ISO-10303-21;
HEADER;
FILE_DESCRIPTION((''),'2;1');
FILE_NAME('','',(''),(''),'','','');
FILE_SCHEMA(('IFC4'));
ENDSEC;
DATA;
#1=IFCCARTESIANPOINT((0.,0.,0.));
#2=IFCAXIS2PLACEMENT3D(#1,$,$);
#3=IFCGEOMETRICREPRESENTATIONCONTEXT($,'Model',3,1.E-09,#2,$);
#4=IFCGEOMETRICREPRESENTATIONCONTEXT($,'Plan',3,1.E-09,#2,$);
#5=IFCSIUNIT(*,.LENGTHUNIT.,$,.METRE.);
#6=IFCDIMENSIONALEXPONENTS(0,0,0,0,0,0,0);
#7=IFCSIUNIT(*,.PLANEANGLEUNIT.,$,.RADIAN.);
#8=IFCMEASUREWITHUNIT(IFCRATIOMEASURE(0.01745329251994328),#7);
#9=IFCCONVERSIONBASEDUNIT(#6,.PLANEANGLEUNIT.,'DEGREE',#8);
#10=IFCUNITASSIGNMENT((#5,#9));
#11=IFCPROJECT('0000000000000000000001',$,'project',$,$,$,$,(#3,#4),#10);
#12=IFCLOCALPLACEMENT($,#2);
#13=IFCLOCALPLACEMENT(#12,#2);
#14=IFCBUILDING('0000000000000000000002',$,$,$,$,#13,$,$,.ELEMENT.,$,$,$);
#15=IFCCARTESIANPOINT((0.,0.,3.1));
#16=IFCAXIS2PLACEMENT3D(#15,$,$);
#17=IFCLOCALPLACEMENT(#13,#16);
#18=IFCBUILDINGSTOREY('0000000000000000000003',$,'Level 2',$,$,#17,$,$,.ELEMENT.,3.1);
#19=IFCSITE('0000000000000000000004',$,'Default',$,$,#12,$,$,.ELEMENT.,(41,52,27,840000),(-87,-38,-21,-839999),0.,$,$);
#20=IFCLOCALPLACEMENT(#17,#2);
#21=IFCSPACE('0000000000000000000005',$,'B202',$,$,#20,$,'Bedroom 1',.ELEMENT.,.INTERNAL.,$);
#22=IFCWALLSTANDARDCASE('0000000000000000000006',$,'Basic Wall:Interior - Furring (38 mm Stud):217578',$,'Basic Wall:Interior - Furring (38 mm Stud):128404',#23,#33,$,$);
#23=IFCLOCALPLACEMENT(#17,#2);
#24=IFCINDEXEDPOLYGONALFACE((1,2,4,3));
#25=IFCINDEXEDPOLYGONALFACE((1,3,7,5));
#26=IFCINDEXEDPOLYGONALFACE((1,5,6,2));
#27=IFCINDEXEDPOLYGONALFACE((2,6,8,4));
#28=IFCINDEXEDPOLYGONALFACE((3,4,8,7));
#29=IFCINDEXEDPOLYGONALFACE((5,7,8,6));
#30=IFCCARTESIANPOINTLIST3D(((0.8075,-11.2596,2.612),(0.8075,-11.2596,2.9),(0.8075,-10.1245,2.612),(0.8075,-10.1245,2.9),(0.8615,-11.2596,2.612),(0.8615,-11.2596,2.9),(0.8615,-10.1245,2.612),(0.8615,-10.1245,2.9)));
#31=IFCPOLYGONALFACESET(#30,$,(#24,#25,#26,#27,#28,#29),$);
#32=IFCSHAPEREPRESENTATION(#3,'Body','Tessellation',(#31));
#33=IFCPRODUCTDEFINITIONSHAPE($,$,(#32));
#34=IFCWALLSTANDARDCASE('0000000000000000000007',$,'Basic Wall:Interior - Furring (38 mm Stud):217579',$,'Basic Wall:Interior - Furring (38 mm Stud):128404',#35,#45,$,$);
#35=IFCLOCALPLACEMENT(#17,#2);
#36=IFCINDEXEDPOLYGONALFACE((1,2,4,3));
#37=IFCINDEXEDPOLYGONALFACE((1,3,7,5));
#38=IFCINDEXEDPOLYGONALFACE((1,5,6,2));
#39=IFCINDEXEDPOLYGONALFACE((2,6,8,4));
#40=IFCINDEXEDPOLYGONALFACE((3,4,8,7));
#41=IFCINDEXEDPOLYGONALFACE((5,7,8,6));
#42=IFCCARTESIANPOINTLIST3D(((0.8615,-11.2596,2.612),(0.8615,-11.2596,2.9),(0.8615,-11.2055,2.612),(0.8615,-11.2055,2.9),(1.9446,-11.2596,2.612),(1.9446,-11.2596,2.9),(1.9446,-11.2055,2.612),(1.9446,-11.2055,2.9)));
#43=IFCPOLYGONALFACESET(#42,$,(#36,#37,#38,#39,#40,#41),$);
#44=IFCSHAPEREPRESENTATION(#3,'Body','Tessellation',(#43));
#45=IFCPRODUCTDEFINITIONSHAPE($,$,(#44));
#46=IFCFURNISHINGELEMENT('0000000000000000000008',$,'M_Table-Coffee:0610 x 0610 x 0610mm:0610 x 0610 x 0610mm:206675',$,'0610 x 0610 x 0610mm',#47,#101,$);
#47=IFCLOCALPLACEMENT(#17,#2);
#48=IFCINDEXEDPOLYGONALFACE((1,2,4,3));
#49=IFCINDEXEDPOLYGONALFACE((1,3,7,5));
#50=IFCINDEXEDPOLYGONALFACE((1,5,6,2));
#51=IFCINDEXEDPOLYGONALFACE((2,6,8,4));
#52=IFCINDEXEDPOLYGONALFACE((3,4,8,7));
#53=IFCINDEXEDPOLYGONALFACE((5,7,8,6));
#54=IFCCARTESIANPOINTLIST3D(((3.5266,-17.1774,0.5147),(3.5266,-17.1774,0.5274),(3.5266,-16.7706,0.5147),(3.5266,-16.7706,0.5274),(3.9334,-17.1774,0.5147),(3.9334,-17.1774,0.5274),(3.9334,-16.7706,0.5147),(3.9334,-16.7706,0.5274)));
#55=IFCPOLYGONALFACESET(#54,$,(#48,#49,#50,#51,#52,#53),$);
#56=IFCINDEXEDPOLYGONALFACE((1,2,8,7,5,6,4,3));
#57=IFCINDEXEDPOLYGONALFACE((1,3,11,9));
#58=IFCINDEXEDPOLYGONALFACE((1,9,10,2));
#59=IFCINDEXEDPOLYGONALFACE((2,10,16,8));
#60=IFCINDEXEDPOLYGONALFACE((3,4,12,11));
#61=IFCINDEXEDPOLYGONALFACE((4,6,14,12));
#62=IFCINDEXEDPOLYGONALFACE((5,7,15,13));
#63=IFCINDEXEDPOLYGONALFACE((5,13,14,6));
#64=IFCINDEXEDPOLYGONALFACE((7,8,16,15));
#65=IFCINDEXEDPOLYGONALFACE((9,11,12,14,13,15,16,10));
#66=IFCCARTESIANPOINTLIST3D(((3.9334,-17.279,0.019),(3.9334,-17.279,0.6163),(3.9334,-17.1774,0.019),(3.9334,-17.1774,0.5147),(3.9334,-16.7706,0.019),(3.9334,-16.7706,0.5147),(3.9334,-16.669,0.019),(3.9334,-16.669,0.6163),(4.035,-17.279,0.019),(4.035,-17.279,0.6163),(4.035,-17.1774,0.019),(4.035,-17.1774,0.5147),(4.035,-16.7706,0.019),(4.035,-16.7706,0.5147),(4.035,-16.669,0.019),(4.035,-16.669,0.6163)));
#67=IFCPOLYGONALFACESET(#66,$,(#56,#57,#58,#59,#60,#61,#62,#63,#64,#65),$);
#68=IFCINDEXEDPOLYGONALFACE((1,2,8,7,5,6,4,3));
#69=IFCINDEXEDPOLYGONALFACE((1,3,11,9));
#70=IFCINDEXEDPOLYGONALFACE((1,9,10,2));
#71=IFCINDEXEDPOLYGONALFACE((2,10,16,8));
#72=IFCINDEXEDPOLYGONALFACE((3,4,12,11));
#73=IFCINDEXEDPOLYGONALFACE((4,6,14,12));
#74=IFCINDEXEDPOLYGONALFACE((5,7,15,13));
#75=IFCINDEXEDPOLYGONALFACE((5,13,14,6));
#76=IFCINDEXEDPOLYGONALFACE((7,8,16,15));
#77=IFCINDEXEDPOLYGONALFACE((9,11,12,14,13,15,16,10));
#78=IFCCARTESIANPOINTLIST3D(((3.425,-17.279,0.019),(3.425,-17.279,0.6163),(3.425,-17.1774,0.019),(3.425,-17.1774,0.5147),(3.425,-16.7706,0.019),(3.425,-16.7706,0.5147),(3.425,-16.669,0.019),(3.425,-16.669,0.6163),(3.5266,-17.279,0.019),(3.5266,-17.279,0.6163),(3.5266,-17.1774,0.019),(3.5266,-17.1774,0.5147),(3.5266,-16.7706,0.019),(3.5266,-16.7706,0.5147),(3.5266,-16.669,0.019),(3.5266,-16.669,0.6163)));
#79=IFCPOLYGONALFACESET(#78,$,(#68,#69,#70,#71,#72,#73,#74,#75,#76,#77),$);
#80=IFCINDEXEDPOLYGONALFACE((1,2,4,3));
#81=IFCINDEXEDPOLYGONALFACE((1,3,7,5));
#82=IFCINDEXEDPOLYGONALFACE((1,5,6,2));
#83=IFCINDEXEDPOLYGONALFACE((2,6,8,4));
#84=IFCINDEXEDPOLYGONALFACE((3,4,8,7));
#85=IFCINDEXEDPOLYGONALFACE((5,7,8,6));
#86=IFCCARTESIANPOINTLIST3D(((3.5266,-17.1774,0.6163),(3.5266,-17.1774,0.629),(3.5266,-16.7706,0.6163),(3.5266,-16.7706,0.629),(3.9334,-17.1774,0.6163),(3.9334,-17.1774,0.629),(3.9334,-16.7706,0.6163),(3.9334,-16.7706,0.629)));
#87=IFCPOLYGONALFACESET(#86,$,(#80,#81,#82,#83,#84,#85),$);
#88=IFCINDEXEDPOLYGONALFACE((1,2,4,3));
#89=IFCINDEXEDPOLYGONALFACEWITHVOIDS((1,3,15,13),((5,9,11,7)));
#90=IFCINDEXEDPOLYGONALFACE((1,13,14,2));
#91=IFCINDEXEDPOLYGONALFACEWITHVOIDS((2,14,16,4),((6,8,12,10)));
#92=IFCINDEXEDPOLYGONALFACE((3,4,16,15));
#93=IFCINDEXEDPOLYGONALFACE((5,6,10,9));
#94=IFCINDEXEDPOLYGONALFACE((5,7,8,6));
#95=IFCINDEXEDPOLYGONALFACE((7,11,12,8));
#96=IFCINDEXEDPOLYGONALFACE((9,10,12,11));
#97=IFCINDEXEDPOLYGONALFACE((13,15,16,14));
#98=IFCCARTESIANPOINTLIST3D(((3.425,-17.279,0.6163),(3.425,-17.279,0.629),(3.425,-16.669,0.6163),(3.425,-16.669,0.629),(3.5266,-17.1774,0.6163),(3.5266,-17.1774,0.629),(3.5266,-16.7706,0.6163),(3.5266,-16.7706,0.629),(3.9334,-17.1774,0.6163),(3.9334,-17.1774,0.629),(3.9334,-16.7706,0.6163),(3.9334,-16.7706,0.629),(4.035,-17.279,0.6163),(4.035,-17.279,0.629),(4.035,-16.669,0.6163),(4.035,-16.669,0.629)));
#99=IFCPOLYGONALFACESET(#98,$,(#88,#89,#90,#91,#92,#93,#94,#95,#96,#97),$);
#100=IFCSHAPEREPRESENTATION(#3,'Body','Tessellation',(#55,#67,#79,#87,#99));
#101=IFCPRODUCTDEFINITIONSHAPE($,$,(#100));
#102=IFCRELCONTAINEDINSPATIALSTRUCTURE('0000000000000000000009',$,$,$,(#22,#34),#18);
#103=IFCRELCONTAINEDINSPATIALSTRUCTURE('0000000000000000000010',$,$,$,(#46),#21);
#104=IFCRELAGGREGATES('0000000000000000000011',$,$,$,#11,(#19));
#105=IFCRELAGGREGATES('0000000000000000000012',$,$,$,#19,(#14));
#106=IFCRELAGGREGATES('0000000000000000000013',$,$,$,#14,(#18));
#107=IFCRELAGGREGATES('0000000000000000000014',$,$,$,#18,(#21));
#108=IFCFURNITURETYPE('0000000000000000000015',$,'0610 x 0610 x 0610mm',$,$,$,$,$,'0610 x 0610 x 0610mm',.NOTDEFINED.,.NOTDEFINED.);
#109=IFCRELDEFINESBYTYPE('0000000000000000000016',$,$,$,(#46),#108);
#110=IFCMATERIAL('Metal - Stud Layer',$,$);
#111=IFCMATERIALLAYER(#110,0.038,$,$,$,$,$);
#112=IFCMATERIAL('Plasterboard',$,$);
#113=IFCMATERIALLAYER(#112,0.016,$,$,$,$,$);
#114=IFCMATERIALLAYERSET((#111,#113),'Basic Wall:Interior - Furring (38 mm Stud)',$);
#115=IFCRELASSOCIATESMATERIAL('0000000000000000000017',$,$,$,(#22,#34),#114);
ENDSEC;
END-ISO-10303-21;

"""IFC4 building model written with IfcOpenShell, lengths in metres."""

from ifc_helpers import new_model, entity, si_unit, converted_unit, frame, frame_2d, origin, origin_2d_with_axis, place, context, project, spatial, polyline, rectangle, outline, extrude, source, transform, mapped, material, layer, layer_set, layer_usage, type_object, type_shapes, element, save


model = new_model("IFC4")

# Units and contexts
model_context = context("Model", 3, precision=1e-09, world=origin())
plan_context = context("Plan", 3, precision=1e-09, world=origin())
ifc_project = project(units=[si_unit("LENGTHUNIT", "METRE"), converted_unit("PLANEANGLEUNIT", "DEGREE", entity("IfcRatioMeasure", 0.01745329251994328), si_unit("PLANEANGLEUNIT", "RADIAN"), dimensions=[0, 0, 0, 0, 0, 0, 0])], contexts=[model_context, plan_context])

# Site, building, storey
site_placement = place(None, origin())
site = spatial("IfcSite", under=ifc_project, at=site_placement, Name="Default", CompositionType="ELEMENT", RefLatitude=(41, 52, 27, 840000), RefLongitude=(-87, -38, -21, -839999), RefElevation=0.0)
building_placement = place(site_placement, origin())
building = spatial("IfcBuilding", under=site, at=building_placement, CompositionType="ELEMENT")
storey_placement = place(building_placement, frame((0.0, 0.0, 3.1)))
storey = spatial("IfcBuildingStorey", under=building, at=storey_placement, Name="Level 2", CompositionType="ELEMENT", Elevation=3.1)

# Shared definitions
ifc_material_1 = material(Name="Metal - Stud Layer")
ifc_material_2 = material(Name="Plasterboard")

# Walls
ifc_layer_1 = layer(ifc_material_1, 0.038)
ifc_layer_2 = layer(ifc_material_2, 0.016)
ifc_layer_set_1 = layer_set([ifc_layer_1, ifc_layer_2], Name="Basic Wall:Interior - Furring (38 mm Stud)")
ifc_layer_usage_1 = layer_usage(ifc_layer_set_1, "AXIS2", "NEGATIVE", 0.027)
wall_1_placement = place(storey_placement, frame((0.8345, -11.2596, 2.612), z_axis=(0.0, 0.0, 1.0), x_axis=(0.0, 1.0, 0.0)))
element("IfcWallStandardCase", 1, at=wall_1_placement, inside=storey, material=ifc_layer_usage_1, Name="Basic Wall:Interior - Furring (38 mm Stud):217578", ObjectType="Basic Wall:Interior - Furring (38 mm Stud):128404", context=model_context, shape_type="SweptSolid", body=[
    extrude(rectangle(XDim=1.1351, YDim=0.054, at=frame_2d((0.5675, 0.0), x_axis=(-1.0, 0.0))), origin(), (0.0, 0.0, 1.0), 0.288),
])
ifc_layer_usage_2 = layer_usage(ifc_layer_set_1, "AXIS2", "NEGATIVE", 0.027)
wall_2_placement = place(storey_placement, frame((1.9446, -11.2325, 2.612), z_axis=(0.0, 0.0, 1.0), x_axis=(-1.0, 0.0, 0.0)))
element("IfcWallStandardCase", 2, at=wall_2_placement, inside=storey, material=ifc_layer_usage_2, Name="Basic Wall:Interior - Furring (38 mm Stud):217579", ObjectType="Basic Wall:Interior - Furring (38 mm Stud):128404", context=model_context, shape_type="SweptSolid", body=[
    extrude(rectangle(XDim=1.0831, YDim=0.054, at=frame_2d((0.5415, 0.0), x_axis=(-1.0, 0.0))), origin(), (0.0, 0.0, 1.0), 0.288),
])

# Shared definitions
space_placement = place(storey_placement, origin())
space = spatial("IfcSpace", under=storey, at=space_placement, Name="B202", LongName="Bedroom 1", CompositionType="ELEMENT", PredefinedType="INTERNAL")

# Furnishing element
furniture_type = type_object("IfcFurnitureType", Name="0610 x 0610 x 0610mm", ElementType="0610 x 0610 x 0610mm", AssemblyPlace="NOTDEFINED")
shared_shape_1 = source(origin(), model_context, "Body", "SweptSolid", [
    extrude(rectangle(XDim=0.4068, YDim=0.4068, at=origin_2d_with_axis()), frame((0.0183, 0.0952, 0.4957), z_axis=(0.0, 0.0, 1.0), x_axis=(-1.0, 0.0, 0.0)), (0.0, 0.0, 1.0), 0.0127),
    extrude(outline(polyline([(-0.2732, -0.305), (0.324, -0.305), (0.324, 0.305), (-0.2732, 0.305), (-0.2732, 0.2034), (0.2225, 0.2034), (0.2225, -0.2034), (-0.2732, -0.2034), (-0.2732, -0.305)])), frame((0.2217, 0.0952, 0.2732), z_axis=(1.0, 0.0, 0.0), x_axis=(0.0, 0.0, 1.0)), (0.0, 0.0, 1.0), 0.1016),
    extrude(outline(polyline([(-0.305, -0.3241), (0.305, -0.3241), (0.305, 0.2733), (0.2034, 0.2733), (0.2034, -0.2224), (-0.2034, -0.2224), (-0.2034, 0.2733), (-0.305, 0.2733), (-0.305, -0.3241)])), frame((-0.2867, 0.0952, 0.2733), z_axis=(1.0, 0.0, 0.0), x_axis=(0.0, -1.0, 0.0)), (0.0, 0.0, 1.0), 0.1016),
    extrude(rectangle(XDim=0.4068, YDim=0.4068, at=origin_2d_with_axis()), frame((0.0183, 0.0952, 0.5973), z_axis=(0.0, 0.0, 1.0), x_axis=(-1.0, 0.0, 0.0)), (0.0, 0.0, 1.0), 0.0127),
    extrude(outline(polyline([(-0.305, -0.305), (0.305, -0.305), (0.305, 0.305), (-0.305, 0.305), (-0.305, -0.305)]), holes=[polyline([(-0.2034, -0.2034), (-0.2034, 0.2034), (0.2034, 0.2034), (0.2034, -0.2034), (-0.2034, -0.2034)])]), frame((0.0183, 0.0952, 0.5973), z_axis=(0.0, 0.0, 1.0), x_axis=(-1.0, 0.0, 0.0)), (0.0, 0.0, 1.0), 0.0127),
])
type_shapes(furniture_type, [shared_shape_1])
furnishing_placement = place(space_placement, frame((3.7117, -17.0692, 0.019)))
element("IfcFurnishingElement", 3, at=furnishing_placement, inside=space, type_object=furniture_type, Name="M_Table-Coffee:0610 x 0610 x 0610mm:0610 x 0610 x 0610mm:206675", ObjectType="0610 x 0610 x 0610mm", context=model_context, shape_type="MappedRepresentation", body=[
    mapped(shared_shape_1, transform((0.0, 0.0, 0.0), scale=1.0)),
])

save(model, "model.ifc")
